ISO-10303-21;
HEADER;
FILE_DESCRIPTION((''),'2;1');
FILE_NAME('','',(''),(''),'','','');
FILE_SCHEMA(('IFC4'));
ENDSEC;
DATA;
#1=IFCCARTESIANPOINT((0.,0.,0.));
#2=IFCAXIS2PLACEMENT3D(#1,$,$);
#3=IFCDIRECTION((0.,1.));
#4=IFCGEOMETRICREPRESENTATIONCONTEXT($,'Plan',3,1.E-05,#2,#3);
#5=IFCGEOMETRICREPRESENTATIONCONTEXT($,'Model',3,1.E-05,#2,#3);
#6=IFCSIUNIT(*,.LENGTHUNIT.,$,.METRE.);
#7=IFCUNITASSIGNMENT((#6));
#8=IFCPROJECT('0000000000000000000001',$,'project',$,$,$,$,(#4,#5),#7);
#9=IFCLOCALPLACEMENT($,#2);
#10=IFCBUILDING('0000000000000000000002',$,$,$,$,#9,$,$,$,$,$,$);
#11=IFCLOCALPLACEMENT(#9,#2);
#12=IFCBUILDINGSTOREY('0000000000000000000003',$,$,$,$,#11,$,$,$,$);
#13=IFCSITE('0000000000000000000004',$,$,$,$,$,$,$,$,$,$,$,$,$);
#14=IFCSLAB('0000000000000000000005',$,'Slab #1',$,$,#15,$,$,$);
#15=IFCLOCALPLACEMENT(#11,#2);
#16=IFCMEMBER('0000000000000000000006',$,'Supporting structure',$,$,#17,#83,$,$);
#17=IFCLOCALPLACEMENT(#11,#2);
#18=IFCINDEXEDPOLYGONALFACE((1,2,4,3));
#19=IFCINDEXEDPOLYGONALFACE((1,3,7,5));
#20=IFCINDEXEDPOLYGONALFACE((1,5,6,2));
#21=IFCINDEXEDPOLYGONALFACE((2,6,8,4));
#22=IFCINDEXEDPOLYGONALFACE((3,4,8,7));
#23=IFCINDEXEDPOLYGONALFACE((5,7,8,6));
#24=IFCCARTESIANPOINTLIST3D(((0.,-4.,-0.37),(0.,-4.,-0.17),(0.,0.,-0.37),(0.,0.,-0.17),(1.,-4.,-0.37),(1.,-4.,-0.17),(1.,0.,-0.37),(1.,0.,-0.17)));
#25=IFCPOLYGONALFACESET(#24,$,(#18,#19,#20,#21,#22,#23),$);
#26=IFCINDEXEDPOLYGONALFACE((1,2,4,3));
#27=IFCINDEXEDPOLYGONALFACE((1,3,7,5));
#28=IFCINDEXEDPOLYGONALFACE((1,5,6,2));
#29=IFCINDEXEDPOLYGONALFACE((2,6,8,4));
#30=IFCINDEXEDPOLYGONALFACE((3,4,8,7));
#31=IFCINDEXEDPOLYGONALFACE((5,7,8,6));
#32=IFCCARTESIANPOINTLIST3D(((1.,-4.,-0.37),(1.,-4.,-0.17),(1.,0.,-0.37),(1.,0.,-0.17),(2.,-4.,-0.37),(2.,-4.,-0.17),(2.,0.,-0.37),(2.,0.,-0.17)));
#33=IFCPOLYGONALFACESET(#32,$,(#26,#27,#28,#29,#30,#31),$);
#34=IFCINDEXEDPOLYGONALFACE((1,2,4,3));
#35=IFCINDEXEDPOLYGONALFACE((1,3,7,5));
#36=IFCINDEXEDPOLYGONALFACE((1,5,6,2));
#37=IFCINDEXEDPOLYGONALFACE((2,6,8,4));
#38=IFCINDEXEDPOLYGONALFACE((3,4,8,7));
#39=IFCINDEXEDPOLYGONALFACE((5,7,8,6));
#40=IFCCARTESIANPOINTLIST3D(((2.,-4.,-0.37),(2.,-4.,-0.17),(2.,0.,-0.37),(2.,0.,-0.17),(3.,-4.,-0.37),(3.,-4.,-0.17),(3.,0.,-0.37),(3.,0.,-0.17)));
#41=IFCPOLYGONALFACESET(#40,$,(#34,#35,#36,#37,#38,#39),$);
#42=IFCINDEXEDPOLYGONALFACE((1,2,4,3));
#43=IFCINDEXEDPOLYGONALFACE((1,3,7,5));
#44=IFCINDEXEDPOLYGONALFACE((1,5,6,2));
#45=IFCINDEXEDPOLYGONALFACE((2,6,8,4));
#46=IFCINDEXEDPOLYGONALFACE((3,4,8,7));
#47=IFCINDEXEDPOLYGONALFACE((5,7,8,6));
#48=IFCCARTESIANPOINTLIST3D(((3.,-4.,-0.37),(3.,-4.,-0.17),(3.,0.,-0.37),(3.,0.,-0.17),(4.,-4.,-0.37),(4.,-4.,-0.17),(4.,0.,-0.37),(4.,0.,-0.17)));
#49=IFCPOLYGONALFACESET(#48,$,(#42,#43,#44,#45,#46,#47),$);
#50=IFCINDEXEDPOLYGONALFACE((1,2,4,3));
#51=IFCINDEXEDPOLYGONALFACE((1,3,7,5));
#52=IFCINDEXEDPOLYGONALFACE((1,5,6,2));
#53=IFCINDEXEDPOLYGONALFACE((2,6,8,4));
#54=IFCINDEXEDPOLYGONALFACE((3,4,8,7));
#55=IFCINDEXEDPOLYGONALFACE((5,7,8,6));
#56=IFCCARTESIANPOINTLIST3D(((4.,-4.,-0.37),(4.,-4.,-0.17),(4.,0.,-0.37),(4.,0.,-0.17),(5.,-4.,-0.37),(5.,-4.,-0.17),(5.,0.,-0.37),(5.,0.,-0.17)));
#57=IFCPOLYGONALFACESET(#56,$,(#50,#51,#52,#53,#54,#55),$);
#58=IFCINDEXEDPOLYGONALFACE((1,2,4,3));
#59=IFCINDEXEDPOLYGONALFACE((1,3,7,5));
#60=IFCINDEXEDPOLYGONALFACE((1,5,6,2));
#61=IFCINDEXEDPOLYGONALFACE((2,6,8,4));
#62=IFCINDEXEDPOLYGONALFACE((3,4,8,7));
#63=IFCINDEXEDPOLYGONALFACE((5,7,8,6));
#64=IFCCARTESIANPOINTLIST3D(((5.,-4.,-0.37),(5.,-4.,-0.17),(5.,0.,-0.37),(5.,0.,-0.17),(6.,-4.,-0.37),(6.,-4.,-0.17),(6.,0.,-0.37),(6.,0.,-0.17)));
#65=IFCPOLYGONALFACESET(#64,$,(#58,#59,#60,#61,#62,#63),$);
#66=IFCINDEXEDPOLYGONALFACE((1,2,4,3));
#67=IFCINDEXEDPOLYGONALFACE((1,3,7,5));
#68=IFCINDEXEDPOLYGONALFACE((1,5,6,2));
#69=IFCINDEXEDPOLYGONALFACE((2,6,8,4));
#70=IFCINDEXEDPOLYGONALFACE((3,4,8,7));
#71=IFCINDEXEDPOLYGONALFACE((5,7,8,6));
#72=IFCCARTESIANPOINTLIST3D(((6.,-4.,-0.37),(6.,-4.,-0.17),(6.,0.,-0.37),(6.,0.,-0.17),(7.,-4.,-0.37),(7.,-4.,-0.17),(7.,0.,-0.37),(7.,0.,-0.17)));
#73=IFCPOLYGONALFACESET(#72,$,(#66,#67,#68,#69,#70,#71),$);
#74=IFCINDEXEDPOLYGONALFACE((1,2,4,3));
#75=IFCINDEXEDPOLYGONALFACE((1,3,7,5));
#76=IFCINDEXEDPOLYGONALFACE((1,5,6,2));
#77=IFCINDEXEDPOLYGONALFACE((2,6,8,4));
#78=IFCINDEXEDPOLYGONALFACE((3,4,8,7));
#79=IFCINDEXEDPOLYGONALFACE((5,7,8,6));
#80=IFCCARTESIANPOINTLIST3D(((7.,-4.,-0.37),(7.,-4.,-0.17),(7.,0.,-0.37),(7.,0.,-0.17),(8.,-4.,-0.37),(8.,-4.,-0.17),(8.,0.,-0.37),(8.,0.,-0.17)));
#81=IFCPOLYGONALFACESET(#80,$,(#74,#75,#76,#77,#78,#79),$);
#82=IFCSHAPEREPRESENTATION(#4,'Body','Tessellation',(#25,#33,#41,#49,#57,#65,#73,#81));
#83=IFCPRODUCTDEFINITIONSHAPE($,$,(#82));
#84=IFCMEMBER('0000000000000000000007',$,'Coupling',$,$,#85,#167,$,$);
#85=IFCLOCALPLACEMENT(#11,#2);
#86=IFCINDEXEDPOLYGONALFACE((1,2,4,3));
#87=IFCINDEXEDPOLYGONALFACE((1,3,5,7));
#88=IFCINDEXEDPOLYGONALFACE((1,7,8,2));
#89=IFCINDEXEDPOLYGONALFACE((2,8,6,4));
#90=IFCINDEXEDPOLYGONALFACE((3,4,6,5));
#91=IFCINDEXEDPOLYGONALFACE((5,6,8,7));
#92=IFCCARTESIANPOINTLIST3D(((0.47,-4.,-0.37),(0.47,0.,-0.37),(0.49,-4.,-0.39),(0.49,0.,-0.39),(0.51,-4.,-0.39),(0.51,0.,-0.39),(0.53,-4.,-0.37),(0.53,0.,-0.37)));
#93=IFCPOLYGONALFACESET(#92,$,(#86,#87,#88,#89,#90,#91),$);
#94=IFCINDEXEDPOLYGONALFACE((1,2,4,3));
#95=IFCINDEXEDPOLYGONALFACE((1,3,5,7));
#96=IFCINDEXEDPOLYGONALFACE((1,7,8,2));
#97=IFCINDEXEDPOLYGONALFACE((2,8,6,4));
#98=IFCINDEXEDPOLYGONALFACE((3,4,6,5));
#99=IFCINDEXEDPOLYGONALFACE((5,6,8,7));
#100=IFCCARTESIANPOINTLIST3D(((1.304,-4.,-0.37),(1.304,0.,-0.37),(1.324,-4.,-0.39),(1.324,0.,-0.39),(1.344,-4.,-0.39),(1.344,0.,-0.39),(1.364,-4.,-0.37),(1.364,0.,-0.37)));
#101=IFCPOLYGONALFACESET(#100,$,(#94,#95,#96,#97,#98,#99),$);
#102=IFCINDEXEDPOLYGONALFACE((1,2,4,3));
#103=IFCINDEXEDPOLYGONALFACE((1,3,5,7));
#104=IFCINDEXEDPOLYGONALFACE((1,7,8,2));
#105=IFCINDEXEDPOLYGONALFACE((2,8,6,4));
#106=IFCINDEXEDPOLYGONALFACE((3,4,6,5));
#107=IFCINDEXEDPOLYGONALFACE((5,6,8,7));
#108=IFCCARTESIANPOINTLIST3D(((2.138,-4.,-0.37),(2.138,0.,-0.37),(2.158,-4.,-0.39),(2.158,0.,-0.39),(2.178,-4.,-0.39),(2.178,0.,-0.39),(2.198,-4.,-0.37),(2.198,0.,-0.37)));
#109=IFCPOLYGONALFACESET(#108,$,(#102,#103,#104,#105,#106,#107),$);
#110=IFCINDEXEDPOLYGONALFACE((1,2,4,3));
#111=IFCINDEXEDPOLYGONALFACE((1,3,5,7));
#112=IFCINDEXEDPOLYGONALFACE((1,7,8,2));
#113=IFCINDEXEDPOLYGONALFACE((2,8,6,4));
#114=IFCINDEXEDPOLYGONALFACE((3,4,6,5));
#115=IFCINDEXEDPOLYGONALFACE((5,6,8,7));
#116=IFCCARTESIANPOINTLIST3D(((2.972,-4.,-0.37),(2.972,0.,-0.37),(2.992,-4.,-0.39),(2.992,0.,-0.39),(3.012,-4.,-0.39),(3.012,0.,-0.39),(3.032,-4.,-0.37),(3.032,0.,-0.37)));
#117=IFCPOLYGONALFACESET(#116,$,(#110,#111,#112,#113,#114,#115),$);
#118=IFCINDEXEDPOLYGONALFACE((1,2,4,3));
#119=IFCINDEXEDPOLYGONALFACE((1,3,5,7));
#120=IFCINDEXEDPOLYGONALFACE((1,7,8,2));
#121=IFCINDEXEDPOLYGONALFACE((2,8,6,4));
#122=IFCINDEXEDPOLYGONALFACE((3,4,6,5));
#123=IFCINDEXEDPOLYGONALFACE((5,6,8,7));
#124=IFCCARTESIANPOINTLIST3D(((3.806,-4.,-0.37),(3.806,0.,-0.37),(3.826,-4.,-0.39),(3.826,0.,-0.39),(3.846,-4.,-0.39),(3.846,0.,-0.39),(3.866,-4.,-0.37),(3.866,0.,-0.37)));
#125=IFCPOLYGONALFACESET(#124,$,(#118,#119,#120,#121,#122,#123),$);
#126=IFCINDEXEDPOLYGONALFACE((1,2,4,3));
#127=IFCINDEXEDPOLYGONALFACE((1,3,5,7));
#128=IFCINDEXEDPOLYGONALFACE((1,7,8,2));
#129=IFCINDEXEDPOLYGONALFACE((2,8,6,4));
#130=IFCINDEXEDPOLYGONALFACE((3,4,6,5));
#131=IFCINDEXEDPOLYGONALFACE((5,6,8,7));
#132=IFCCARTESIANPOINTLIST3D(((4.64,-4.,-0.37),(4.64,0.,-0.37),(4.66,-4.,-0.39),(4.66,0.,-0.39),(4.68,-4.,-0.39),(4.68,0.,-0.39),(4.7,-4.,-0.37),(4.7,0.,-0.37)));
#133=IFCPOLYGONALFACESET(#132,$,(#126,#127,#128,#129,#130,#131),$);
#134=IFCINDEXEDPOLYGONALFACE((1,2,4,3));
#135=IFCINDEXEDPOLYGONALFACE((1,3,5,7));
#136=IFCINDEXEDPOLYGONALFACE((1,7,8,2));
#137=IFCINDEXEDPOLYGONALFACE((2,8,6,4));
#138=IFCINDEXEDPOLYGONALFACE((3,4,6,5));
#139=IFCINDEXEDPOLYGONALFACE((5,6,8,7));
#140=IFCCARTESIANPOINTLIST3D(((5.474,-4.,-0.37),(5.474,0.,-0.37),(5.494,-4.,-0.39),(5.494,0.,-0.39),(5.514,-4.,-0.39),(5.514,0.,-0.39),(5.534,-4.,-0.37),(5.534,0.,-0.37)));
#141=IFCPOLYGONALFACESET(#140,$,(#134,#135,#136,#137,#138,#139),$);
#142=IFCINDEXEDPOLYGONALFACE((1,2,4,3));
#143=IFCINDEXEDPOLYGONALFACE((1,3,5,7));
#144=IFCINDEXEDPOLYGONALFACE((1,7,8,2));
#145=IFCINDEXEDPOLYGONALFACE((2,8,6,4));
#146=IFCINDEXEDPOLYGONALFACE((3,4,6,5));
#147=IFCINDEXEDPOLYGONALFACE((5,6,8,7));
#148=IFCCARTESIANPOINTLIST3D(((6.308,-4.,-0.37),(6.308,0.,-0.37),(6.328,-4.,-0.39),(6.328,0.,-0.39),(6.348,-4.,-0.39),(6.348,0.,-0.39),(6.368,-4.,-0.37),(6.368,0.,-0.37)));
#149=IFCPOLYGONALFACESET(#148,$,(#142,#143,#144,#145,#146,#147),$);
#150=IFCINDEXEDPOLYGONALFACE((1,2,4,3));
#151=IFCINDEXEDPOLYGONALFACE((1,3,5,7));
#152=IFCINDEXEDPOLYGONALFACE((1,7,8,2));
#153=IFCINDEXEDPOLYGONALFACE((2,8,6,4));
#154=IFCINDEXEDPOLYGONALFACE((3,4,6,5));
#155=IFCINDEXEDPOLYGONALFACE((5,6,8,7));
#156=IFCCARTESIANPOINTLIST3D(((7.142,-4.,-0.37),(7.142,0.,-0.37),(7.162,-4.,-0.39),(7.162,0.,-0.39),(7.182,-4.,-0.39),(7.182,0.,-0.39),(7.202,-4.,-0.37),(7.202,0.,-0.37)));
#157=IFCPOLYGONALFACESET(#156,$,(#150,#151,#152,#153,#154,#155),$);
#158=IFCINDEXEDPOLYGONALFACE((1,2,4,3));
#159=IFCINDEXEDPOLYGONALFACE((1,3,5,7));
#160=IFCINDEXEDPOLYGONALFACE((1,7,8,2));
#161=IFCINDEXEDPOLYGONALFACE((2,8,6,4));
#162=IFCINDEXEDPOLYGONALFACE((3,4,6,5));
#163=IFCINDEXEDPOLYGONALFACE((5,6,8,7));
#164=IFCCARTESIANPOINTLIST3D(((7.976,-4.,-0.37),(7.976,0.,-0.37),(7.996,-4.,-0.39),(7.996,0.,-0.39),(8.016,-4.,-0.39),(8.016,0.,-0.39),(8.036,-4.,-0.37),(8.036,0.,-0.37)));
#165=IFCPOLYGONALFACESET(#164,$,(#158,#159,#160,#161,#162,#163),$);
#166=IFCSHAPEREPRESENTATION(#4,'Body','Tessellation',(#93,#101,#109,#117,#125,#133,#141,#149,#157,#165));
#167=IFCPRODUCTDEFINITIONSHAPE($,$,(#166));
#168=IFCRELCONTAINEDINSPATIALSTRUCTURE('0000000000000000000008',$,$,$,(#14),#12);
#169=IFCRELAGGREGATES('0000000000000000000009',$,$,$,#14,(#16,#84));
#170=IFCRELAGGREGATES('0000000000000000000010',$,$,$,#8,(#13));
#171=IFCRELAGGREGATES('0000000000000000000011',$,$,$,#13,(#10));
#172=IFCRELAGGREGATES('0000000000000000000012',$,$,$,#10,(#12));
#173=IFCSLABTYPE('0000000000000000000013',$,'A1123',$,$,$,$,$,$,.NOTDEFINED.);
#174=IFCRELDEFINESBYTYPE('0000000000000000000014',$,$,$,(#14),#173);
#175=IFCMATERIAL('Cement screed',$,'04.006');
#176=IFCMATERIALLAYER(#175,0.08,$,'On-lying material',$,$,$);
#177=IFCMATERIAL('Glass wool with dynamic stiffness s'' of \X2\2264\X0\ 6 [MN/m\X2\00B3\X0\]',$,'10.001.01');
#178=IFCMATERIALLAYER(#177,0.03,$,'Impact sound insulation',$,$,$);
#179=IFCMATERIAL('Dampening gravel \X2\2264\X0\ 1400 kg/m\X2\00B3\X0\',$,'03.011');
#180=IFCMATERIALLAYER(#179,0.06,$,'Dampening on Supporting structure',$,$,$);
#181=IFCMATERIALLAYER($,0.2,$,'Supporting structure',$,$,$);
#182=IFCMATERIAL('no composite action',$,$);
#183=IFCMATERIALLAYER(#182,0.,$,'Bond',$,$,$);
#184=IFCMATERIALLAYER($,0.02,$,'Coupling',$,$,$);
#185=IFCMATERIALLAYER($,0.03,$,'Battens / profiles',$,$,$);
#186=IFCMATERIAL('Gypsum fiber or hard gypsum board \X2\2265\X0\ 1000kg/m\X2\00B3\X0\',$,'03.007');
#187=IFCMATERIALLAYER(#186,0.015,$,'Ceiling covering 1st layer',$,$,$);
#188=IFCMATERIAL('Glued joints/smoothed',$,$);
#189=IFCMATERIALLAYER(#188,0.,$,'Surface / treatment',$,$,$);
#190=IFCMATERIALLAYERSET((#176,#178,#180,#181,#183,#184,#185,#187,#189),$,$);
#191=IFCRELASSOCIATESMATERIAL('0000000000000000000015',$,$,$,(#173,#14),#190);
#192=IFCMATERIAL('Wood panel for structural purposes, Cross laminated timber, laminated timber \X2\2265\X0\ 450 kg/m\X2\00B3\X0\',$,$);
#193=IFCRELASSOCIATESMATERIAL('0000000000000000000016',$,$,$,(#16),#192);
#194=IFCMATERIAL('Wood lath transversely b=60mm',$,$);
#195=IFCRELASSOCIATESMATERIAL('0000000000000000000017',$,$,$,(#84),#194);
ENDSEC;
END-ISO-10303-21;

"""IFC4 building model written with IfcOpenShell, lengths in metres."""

from ifc_helpers import new_model, si_unit, direction, frame, frame_2d, origin, place, context, project, spatial, polyline, rectangle, outline, extrude, material, layer, layer_set, type_object, element, aggregate, save


model = new_model("IFC4")

# Units and contexts
plan_context = context("Plan", 3, precision=1e-05, world=origin(), true_north=direction((0.0, 1.0)))
model_context = context("Model", 3, precision=1e-05, world=origin(), true_north=direction((0.0, 1.0)))
ifc_project = project(units=[si_unit("LENGTHUNIT", "METRE")], contexts=[plan_context, model_context])

# Site, building, storey
site = spatial("IfcSite", under=ifc_project)
building_placement = place(None, origin())
building = spatial("IfcBuilding", under=site, at=building_placement)
storey_placement = place(building_placement, origin())
storey = spatial("IfcBuildingStorey", under=building, at=storey_placement)

# Slab, members
ifc_material_1 = material(Name="Cement screed", Category="04.006")
ifc_layer_1 = layer(ifc_material_1, 0.08, Name="On-lying material")
ifc_material_2 = material(Name="Glass wool with dynamic stiffness s' of ≤ 6 [MN/m³]", Category="10.001.01")
ifc_layer_2 = layer(ifc_material_2, 0.03, Name="Impact sound insulation")
ifc_material_3 = material(Name="Dampening gravel ≤ 1400 kg/m³", Category="03.011")
ifc_layer_3 = layer(ifc_material_3, 0.06, Name="Dampening on Supporting structure")
ifc_layer_4 = layer(None, 0.2, Name="Supporting structure")
ifc_material_4 = material(Name="no composite action")
ifc_layer_5 = layer(ifc_material_4, 0.0, Name="Bond")
ifc_layer_6 = layer(None, 0.02, Name="Coupling")
ifc_layer_7 = layer(None, 0.03, Name="Battens / profiles")
ifc_material_5 = material(Name="Gypsum fiber or hard gypsum board ≥ 1000kg/m³", Category="03.007")
ifc_layer_8 = layer(ifc_material_5, 0.015, Name="Ceiling covering 1st layer")
ifc_material_6 = material(Name="Glued joints/smoothed")
ifc_layer_9 = layer(ifc_material_6, 0.0, Name="Surface / treatment")
ifc_layer_set = layer_set([ifc_layer_1, ifc_layer_2, ifc_layer_3, ifc_layer_4, ifc_layer_5, ifc_layer_6, ifc_layer_7, ifc_layer_8, ifc_layer_9])
slab_type = type_object("IfcSlabType", Name="A1123", PredefinedType="NOTDEFINED", material=ifc_layer_set)
slab_placement = place(None, frame((0.0, 0.0, 0.0), z_axis=(0.0, 0.0, -1.0), x_axis=(1.0, 0.0, 0.0)))
slab = element("IfcSlab", 1, at=slab_placement, inside=storey, type_object=slab_type, material=ifc_layer_set, Name="Slab #1")
ifc_material_7 = material(Name="Wood panel for structural purposes, Cross laminated timber, laminated timber ≥ 450 kg/m³")
member_1_placement = place(slab_placement, origin())
member_1 = element("IfcMember", 2, at=member_1_placement, material=ifc_material_7, Name="Supporting structure", context=plan_context, shape_type="SweptSolid", body=[
    extrude(rectangle(XDim=1.0, YDim=0.2, at=frame_2d((0.5, 0.1), x_axis=(1.0, 0.0))), frame((0.0, 4.0, 0.17), z_axis=(0.0, -1.0, 0.0), x_axis=(1.0, 0.0, 0.0)), (0.0, 0.0, 1.0), 4.0),
    extrude(rectangle(XDim=1.0, YDim=0.2, at=frame_2d((0.5, 0.1), x_axis=(1.0, 0.0))), frame((1.0, 4.0, 0.17), z_axis=(0.0, -1.0, 0.0), x_axis=(1.0, 0.0, 0.0)), (0.0, 0.0, 1.0), 4.0),
    extrude(rectangle(XDim=1.0, YDim=0.2, at=frame_2d((0.5, 0.1), x_axis=(1.0, 0.0))), frame((2.0, 4.0, 0.17), z_axis=(0.0, -1.0, 0.0), x_axis=(1.0, 0.0, 0.0)), (0.0, 0.0, 1.0), 4.0),
    extrude(rectangle(XDim=1.0, YDim=0.2, at=frame_2d((0.5, 0.1), x_axis=(1.0, 0.0))), frame((3.0, 4.0, 0.17), z_axis=(0.0, -1.0, 0.0), x_axis=(1.0, 0.0, 0.0)), (0.0, 0.0, 1.0), 4.0),
    extrude(rectangle(XDim=1.0, YDim=0.2, at=frame_2d((0.5, 0.1), x_axis=(1.0, 0.0))), frame((4.0, 4.0, 0.17), z_axis=(0.0, -1.0, 0.0), x_axis=(1.0, 0.0, 0.0)), (0.0, 0.0, 1.0), 4.0),
    extrude(rectangle(XDim=1.0, YDim=0.2, at=frame_2d((0.5, 0.1), x_axis=(1.0, 0.0))), frame((5.0, 4.0, 0.17), z_axis=(0.0, -1.0, 0.0), x_axis=(1.0, 0.0, 0.0)), (0.0, 0.0, 1.0), 4.0),
    extrude(rectangle(XDim=1.0, YDim=0.2, at=frame_2d((0.5, 0.1), x_axis=(1.0, 0.0))), frame((6.0, 4.0, 0.17), z_axis=(0.0, -1.0, 0.0), x_axis=(1.0, 0.0, 0.0)), (0.0, 0.0, 1.0), 4.0),
    extrude(rectangle(XDim=1.0, YDim=0.2, at=frame_2d((0.5, 0.1), x_axis=(1.0, 0.0))), frame((7.0, 4.0, 0.17), z_axis=(0.0, -1.0, 0.0), x_axis=(1.0, 0.0, 0.0)), (0.0, 0.0, 1.0), 4.0),
])
ifc_material_8 = material(Name="Wood lath transversely b=60mm")
member_2_placement = place(slab_placement, origin())
member_2 = element("IfcMember", 3, at=member_2_placement, material=ifc_material_8, Name="Coupling", context=plan_context, shape_type="SweptSolid", body=[
    extrude(outline(polyline([(0.0, 0.0), (0.06, 0.0), (0.04, 0.02), (0.02, 0.02), (0.0, 0.0)])), frame((0.47, 4.0, 0.37), z_axis=(0.0, -1.0, 0.0), x_axis=(1.0, 0.0, 0.0)), (0.0, 0.0, 1.0), 4.0),
    extrude(outline(polyline([(0.0, 0.0), (0.06, 0.0), (0.04, 0.02), (0.02, 0.02), (0.0, 0.0)])), frame((1.304, 4.0, 0.37), z_axis=(0.0, -1.0, 0.0), x_axis=(1.0, 0.0, 0.0)), (0.0, 0.0, 1.0), 4.0),
    extrude(outline(polyline([(0.0, 0.0), (0.06, 0.0), (0.04, 0.02), (0.02, 0.02), (0.0, 0.0)])), frame((2.138, 4.0, 0.37), z_axis=(0.0, -1.0, 0.0), x_axis=(1.0, 0.0, 0.0)), (0.0, 0.0, 1.0), 4.0),
    extrude(outline(polyline([(0.0, 0.0), (0.06, 0.0), (0.04, 0.02), (0.02, 0.02), (0.0, 0.0)])), frame((2.972, 4.0, 0.37), z_axis=(0.0, -1.0, 0.0), x_axis=(1.0, 0.0, 0.0)), (0.0, 0.0, 1.0), 4.0),
    extrude(outline(polyline([(0.0, 0.0), (0.06, 0.0), (0.04, 0.02), (0.02, 0.02), (0.0, 0.0)])), frame((3.806, 4.0, 0.37), z_axis=(0.0, -1.0, 0.0), x_axis=(1.0, 0.0, 0.0)), (0.0, 0.0, 1.0), 4.0),
    extrude(outline(polyline([(0.0, 0.0), (0.06, 0.0), (0.04, 0.02), (0.02, 0.02), (0.0, 0.0)])), frame((4.64, 4.0, 0.37), z_axis=(0.0, -1.0, 0.0), x_axis=(1.0, 0.0, 0.0)), (0.0, 0.0, 1.0), 4.0),
    extrude(outline(polyline([(0.0, 0.0), (0.06, 0.0), (0.04, 0.02), (0.02, 0.02), (0.0, 0.0)])), frame((5.474, 4.0, 0.37), z_axis=(0.0, -1.0, 0.0), x_axis=(1.0, 0.0, 0.0)), (0.0, 0.0, 1.0), 4.0),
    extrude(outline(polyline([(0.0, 0.0), (0.06, 0.0), (0.04, 0.02), (0.02, 0.02), (0.0, 0.0)])), frame((6.308, 4.0, 0.37), z_axis=(0.0, -1.0, 0.0), x_axis=(1.0, 0.0, 0.0)), (0.0, 0.0, 1.0), 4.0),
    extrude(outline(polyline([(0.0, 0.0), (0.06, 0.0), (0.04, 0.02), (0.02, 0.02), (0.0, 0.0)])), frame((7.142, 4.0, 0.37), z_axis=(0.0, -1.0, 0.0), x_axis=(1.0, 0.0, 0.0)), (0.0, 0.0, 1.0), 4.0),
    extrude(outline(polyline([(0.0, 0.0), (0.06, 0.0), (0.04, 0.02), (0.02, 0.02), (0.0, 0.0)])), frame((7.976, 4.0, 0.37), z_axis=(0.0, -1.0, 0.0), x_axis=(1.0, 0.0, 0.0)), (0.0, 0.0, 1.0), 4.0),
])
aggregate(slab, [member_1, member_2])

save(model, "model.ifc")
